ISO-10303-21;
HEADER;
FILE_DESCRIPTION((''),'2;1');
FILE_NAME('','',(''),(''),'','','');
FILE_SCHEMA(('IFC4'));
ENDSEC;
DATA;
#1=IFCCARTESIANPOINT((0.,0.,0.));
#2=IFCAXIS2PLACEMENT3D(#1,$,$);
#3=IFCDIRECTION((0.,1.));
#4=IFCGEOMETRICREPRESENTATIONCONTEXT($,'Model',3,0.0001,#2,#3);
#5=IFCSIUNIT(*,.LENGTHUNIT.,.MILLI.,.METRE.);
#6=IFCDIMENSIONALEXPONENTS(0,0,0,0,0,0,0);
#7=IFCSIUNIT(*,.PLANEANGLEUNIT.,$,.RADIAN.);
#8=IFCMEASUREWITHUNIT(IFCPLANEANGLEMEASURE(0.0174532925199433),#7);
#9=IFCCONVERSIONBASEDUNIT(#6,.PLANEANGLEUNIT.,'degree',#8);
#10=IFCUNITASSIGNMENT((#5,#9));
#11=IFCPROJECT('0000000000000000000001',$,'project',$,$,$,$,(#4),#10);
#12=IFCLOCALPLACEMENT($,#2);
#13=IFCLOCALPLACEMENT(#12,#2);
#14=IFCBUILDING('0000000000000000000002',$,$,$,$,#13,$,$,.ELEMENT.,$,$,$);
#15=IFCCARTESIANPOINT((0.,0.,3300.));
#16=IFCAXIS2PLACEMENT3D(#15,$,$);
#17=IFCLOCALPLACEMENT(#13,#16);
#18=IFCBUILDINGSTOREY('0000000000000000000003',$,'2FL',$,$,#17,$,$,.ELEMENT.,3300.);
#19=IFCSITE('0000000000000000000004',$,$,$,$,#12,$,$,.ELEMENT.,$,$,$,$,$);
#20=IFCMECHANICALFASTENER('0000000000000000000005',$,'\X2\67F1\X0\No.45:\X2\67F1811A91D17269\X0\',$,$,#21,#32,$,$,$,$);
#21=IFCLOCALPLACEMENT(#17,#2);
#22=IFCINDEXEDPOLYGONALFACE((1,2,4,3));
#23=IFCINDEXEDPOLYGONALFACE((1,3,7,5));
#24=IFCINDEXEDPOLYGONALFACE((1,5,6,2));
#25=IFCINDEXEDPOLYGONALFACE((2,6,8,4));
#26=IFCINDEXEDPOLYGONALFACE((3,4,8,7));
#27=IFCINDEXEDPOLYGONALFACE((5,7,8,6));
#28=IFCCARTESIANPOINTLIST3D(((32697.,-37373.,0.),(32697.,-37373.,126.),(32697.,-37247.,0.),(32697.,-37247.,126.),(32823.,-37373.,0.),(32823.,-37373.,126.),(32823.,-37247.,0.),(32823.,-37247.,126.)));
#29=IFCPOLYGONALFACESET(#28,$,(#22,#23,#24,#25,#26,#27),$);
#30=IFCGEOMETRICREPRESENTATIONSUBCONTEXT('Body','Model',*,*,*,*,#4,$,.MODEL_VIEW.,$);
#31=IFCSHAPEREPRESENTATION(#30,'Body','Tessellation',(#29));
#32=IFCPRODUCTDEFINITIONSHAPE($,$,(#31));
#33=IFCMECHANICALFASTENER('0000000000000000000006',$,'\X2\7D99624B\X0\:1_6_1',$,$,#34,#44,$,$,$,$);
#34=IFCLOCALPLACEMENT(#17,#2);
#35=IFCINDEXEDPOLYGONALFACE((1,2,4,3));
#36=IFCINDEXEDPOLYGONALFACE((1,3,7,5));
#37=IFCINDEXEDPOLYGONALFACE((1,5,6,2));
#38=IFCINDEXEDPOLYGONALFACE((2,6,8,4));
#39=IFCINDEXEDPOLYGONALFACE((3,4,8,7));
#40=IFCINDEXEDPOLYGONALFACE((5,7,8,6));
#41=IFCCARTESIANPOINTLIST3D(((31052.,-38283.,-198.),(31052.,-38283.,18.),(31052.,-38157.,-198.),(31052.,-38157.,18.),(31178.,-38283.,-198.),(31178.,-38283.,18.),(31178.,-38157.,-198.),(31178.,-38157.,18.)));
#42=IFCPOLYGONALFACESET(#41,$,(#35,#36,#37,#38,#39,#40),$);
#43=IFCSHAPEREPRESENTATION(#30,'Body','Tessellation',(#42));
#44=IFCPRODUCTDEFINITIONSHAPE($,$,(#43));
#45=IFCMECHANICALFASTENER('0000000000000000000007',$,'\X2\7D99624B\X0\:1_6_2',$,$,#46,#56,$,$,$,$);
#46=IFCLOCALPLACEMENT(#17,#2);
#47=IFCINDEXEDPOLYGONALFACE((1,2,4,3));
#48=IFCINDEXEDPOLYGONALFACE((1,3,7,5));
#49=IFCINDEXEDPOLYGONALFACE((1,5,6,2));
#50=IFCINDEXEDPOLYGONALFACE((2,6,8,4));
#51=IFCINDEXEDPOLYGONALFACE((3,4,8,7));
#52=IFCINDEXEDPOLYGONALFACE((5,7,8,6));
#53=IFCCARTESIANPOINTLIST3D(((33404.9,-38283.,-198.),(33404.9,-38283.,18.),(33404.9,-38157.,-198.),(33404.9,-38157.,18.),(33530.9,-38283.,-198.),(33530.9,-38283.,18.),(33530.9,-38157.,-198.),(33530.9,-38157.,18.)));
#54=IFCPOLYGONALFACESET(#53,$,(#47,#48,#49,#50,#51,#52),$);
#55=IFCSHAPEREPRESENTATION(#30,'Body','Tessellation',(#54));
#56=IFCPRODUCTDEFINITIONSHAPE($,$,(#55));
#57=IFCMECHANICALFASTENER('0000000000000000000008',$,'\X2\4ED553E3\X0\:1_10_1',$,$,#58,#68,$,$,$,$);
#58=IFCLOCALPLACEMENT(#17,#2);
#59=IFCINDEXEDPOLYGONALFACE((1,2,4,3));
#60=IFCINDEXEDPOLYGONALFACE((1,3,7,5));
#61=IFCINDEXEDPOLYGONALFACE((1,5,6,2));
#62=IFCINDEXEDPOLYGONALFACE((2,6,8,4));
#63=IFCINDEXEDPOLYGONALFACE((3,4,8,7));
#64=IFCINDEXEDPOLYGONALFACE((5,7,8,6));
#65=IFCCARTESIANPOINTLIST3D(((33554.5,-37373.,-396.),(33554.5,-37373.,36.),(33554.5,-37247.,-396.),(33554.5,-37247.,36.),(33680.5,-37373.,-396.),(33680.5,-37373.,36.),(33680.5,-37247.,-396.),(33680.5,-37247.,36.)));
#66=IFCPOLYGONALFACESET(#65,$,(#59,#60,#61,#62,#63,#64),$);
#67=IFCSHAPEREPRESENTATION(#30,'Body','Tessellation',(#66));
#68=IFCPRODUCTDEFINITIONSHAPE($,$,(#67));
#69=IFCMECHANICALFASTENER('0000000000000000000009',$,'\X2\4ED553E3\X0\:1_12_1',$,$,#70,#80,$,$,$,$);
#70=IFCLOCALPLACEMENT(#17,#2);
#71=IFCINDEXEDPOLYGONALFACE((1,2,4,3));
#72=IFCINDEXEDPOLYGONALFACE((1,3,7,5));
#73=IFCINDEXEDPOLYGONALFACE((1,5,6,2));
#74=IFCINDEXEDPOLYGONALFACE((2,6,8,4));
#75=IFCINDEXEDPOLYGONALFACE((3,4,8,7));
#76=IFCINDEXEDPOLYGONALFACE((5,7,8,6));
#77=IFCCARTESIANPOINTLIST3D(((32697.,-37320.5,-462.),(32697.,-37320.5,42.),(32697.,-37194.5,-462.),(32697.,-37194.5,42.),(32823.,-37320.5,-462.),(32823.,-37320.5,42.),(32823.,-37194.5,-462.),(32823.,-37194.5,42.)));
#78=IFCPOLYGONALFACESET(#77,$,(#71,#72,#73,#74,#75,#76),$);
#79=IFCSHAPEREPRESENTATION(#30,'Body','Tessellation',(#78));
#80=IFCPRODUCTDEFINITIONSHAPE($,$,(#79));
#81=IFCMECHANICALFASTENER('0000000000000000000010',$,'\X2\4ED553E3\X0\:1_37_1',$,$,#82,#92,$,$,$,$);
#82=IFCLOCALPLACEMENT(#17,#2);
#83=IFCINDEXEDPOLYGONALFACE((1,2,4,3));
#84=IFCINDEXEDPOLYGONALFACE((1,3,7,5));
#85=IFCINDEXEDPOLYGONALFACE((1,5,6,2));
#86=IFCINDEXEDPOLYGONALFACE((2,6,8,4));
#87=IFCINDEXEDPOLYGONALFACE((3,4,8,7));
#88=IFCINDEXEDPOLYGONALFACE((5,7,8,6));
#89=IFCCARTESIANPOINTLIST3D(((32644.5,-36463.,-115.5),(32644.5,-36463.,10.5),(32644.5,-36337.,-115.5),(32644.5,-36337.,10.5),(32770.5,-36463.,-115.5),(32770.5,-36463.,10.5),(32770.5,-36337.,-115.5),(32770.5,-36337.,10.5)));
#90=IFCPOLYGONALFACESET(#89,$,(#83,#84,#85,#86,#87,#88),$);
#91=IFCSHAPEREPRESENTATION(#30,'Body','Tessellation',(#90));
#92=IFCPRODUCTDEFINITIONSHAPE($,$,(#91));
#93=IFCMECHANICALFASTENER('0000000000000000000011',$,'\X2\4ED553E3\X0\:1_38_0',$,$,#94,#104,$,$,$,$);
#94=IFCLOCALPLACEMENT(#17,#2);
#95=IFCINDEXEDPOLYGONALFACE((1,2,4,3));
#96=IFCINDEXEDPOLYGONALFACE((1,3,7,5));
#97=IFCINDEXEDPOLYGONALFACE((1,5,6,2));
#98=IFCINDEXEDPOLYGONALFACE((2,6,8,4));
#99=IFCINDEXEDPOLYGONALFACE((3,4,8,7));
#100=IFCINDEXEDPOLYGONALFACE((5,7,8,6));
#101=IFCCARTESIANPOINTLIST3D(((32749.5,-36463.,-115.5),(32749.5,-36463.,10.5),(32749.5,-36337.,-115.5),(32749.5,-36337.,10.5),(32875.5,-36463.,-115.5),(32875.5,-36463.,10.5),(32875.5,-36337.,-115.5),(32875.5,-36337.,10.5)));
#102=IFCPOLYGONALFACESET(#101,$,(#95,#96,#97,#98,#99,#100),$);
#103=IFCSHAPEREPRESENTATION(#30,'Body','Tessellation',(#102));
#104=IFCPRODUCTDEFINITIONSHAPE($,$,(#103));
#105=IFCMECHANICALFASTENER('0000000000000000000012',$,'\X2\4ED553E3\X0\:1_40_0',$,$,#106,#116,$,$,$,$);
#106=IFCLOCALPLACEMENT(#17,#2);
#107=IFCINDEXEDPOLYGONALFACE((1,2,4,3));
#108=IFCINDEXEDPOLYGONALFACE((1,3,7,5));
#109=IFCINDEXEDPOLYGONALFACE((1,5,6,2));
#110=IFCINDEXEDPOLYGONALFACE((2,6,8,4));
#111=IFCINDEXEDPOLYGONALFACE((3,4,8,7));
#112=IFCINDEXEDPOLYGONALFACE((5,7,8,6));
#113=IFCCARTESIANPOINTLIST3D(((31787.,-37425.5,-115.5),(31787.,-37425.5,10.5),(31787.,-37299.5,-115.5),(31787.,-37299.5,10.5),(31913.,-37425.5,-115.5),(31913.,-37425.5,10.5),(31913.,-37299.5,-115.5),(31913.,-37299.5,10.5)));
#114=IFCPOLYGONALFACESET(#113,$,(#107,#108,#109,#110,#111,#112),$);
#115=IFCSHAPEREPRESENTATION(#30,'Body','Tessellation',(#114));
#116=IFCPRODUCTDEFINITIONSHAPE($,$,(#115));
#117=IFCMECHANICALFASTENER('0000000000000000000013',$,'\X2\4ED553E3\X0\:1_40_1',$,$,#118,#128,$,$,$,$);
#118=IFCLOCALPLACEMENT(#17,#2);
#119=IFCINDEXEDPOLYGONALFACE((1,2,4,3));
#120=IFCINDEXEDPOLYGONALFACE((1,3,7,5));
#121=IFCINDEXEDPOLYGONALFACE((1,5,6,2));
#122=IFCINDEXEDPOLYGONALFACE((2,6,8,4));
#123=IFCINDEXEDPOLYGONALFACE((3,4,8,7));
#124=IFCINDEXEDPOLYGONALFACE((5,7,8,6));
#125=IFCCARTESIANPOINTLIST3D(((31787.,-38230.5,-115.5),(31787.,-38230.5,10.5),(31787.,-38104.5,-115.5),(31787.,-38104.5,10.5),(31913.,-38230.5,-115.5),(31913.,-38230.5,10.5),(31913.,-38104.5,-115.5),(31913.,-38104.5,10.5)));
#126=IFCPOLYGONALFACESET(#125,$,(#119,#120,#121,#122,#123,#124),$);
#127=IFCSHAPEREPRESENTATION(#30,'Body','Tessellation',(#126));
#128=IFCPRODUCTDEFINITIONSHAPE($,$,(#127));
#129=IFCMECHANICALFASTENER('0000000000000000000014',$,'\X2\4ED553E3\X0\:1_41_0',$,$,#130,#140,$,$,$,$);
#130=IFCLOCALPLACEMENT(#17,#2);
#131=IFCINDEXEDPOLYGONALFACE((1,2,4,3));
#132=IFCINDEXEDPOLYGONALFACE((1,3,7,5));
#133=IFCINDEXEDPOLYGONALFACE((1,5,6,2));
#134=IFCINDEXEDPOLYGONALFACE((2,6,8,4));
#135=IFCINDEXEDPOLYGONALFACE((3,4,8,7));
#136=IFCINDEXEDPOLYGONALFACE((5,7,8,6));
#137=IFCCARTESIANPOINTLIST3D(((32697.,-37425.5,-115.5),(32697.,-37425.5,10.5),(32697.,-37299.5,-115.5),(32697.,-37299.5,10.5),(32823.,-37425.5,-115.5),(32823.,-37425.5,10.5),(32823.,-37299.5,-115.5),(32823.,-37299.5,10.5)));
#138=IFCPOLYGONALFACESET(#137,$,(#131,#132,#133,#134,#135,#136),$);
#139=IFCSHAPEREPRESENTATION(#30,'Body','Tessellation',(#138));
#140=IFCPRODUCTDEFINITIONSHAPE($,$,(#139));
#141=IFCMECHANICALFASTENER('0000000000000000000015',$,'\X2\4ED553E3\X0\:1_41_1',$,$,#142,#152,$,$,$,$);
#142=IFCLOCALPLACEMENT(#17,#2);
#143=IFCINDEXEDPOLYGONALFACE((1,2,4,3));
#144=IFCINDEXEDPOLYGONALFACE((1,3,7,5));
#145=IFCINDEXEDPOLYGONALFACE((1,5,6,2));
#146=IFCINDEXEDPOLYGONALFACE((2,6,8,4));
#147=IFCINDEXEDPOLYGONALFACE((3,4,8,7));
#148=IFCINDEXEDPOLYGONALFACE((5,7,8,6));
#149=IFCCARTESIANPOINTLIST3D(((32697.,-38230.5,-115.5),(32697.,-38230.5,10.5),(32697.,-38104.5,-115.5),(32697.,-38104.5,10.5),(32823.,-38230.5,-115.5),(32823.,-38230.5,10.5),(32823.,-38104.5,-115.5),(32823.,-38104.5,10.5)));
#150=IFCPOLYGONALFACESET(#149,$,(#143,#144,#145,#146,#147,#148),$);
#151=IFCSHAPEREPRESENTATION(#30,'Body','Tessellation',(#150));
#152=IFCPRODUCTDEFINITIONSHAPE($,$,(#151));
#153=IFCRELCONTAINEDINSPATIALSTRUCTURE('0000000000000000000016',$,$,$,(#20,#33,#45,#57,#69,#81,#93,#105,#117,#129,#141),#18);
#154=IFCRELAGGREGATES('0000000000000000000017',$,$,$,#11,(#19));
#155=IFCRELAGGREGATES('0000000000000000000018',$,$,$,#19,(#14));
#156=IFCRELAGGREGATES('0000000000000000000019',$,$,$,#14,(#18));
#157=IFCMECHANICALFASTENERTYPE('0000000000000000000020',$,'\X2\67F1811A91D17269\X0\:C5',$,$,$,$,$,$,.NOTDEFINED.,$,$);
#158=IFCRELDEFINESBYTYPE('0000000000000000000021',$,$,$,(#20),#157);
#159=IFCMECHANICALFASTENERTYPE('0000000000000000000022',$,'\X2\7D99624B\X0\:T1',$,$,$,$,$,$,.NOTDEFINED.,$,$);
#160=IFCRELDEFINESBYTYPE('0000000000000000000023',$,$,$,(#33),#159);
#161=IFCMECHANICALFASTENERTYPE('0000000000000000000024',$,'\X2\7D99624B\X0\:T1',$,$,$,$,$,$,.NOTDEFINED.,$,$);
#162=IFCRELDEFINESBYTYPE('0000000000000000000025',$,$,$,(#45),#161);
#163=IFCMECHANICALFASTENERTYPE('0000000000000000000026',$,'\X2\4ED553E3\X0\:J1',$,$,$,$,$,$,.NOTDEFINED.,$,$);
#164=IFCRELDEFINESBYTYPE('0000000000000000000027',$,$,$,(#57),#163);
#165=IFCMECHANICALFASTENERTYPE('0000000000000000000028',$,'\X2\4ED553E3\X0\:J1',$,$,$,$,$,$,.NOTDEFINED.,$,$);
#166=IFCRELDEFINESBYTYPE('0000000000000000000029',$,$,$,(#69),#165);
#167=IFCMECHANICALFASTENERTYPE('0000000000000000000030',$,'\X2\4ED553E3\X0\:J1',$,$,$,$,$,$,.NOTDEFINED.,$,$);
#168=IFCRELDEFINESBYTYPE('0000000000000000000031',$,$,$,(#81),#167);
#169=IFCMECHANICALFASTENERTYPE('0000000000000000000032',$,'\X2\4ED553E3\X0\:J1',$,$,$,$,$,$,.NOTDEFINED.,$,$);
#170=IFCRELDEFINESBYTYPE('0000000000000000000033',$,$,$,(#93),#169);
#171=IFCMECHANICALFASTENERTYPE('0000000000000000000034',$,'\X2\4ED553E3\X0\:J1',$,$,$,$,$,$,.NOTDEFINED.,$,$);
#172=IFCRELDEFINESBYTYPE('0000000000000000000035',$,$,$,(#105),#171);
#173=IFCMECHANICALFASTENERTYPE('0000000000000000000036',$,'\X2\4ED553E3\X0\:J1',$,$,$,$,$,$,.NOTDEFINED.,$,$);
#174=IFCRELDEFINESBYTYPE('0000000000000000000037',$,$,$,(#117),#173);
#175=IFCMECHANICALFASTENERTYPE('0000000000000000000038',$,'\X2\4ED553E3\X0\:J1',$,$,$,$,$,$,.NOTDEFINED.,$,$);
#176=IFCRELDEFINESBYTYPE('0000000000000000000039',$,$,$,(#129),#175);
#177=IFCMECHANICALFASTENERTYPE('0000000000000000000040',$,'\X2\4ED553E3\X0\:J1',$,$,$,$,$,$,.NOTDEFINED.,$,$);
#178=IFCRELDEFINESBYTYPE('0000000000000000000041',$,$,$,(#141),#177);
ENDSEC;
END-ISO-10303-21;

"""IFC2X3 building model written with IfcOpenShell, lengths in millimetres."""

from ifc_helpers import new_model, entity, si_unit, converted_unit, direction, frame, origin, origin_with_axes, origin_2d, place, context, subcontext, project, spatial, rectangle, extrude, type_object, element, save


model = new_model("IFC2X3")

# Units and contexts
model_context = context("Model", 3, precision=0.0001, world=origin(), true_north=direction((0.0, 1.0)))
body_context = subcontext(model_context, "Body", "Model", "MODEL_VIEW")
ifc_project = project(units=[si_unit("LENGTHUNIT", "METRE", prefix="MILLI"), converted_unit("PLANEANGLEUNIT", "degree", entity("IfcPlaneAngleMeasure", 0.0174532925199433), si_unit("PLANEANGLEUNIT", "RADIAN"), dimensions=[0, 0, 0, 0, 0, 0, 0])], contexts=[model_context])

# Site, building, storey
site_placement = place(None, origin())
site = spatial("IfcSite", under=ifc_project, at=site_placement, CompositionType="ELEMENT")
building_placement = place(site_placement, origin())
building = spatial("IfcBuilding", under=site, at=building_placement, CompositionType="ELEMENT")
storey_placement = place(building_placement, frame((0.0, 0.0, 3300.0)))
storey = spatial("IfcBuildingStorey", under=building, at=storey_placement, Name="2FL", CompositionType="ELEMENT", Elevation=3300.0)

# Mechanical fasteners
mechanical_fastener_type_1 = type_object("IfcMechanicalFastenerType", Name="柱脚金物:C5")
mechanical_fastener_1_placement = place(storey_placement, frame((32760.0, -37310.0, 0.0)))
element("IfcMechanicalFastener", 1, at=mechanical_fastener_1_placement, inside=storey, type_object=mechanical_fastener_type_1, Name="柱No.45:柱脚金物", context=body_context, shape_type="SweptSolid", body=[
    extrude(rectangle(XDim=126.0, YDim=126.0, at=origin_2d()), origin_with_axes(), (0.0, 0.0, 1.0), 126.0),
])
mechanical_fastener_type_2 = type_object("IfcMechanicalFastenerType", Name="継手:T1")
mechanical_fastener_2_placement = place(storey_placement, frame((31115.0, -38220.0, -198.0)))
element("IfcMechanicalFastener", 2, at=mechanical_fastener_2_placement, inside=storey, type_object=mechanical_fastener_type_2, Name="継手:1_6_1", context=body_context, shape_type="SweptSolid", body=[
    extrude(rectangle(XDim=126.0, YDim=126.0, at=origin_2d()), origin_with_axes(), (0.0, 0.0, 1.0), 216.0),
])
mechanical_fastener_type_3 = type_object("IfcMechanicalFastenerType", Name="継手:T1")
mechanical_fastener_3_placement = place(storey_placement, frame((33467.9, -38220.0, -198.0)))
element("IfcMechanicalFastener", 3, at=mechanical_fastener_3_placement, inside=storey, type_object=mechanical_fastener_type_3, Name="継手:1_6_2", context=body_context, shape_type="SweptSolid", body=[
    extrude(rectangle(XDim=126.0, YDim=126.0, at=origin_2d()), origin_with_axes(), (0.0, 0.0, 1.0), 216.0),
])
mechanical_fastener_type_4 = type_object("IfcMechanicalFastenerType", Name="仕口:J1")
mechanical_fastener_4_placement = place(storey_placement, frame((33617.5, -37310.0, -396.0)))
element("IfcMechanicalFastener", 4, at=mechanical_fastener_4_placement, inside=storey, type_object=mechanical_fastener_type_4, Name="仕口:1_10_1", context=body_context, shape_type="SweptSolid", body=[
    extrude(rectangle(XDim=126.0, YDim=126.0, at=origin_2d()), origin_with_axes(), (0.0, 0.0, 1.0), 432.0),
])
mechanical_fastener_type_5 = type_object("IfcMechanicalFastenerType", Name="仕口:J1")
mechanical_fastener_5_placement = place(storey_placement, frame((32760.0, -37257.5, -462.0)))
element("IfcMechanicalFastener", 5, at=mechanical_fastener_5_placement, inside=storey, type_object=mechanical_fastener_type_5, Name="仕口:1_12_1", context=body_context, shape_type="SweptSolid", body=[
    extrude(rectangle(XDim=126.0, YDim=126.0, at=origin_2d()), origin_with_axes(), (0.0, 0.0, 1.0), 504.0),
])
mechanical_fastener_type_6 = type_object("IfcMechanicalFastenerType", Name="仕口:J1")
mechanical_fastener_6_placement = place(storey_placement, frame((32707.5, -36400.0, -115.5)))
element("IfcMechanicalFastener", 6, at=mechanical_fastener_6_placement, inside=storey, type_object=mechanical_fastener_type_6, Name="仕口:1_37_1", context=body_context, shape_type="SweptSolid", body=[
    extrude(rectangle(XDim=126.0, YDim=126.0, at=origin_2d()), origin_with_axes(), (0.0, 0.0, 1.0), 126.0),
])
mechanical_fastener_type_7 = type_object("IfcMechanicalFastenerType", Name="仕口:J1")
mechanical_fastener_7_placement = place(storey_placement, frame((32812.5, -36400.0, -115.5)))
element("IfcMechanicalFastener", 7, at=mechanical_fastener_7_placement, inside=storey, type_object=mechanical_fastener_type_7, Name="仕口:1_38_0", context=body_context, shape_type="SweptSolid", body=[
    extrude(rectangle(XDim=126.0, YDim=126.0, at=origin_2d()), origin_with_axes(), (0.0, 0.0, 1.0), 126.0),
])
mechanical_fastener_type_8 = type_object("IfcMechanicalFastenerType", Name="仕口:J1")
mechanical_fastener_8_placement = place(storey_placement, frame((31850.0, -37362.5, -115.5)))
element("IfcMechanicalFastener", 8, at=mechanical_fastener_8_placement, inside=storey, type_object=mechanical_fastener_type_8, Name="仕口:1_40_0", context=body_context, shape_type="SweptSolid", body=[
    extrude(rectangle(XDim=126.0, YDim=126.0, at=origin_2d()), origin_with_axes(), (0.0, 0.0, 1.0), 126.0),
])
mechanical_fastener_type_9 = type_object("IfcMechanicalFastenerType", Name="仕口:J1")
mechanical_fastener_9_placement = place(storey_placement, frame((31850.0, -38167.5, -115.5)))
element("IfcMechanicalFastener", 9, at=mechanical_fastener_9_placement, inside=storey, type_object=mechanical_fastener_type_9, Name="仕口:1_40_1", context=body_context, shape_type="SweptSolid", body=[
    extrude(rectangle(XDim=126.0, YDim=126.0, at=origin_2d()), origin_with_axes(), (0.0, 0.0, 1.0), 126.0),
])
mechanical_fastener_type_10 = type_object("IfcMechanicalFastenerType", Name="仕口:J1")
mechanical_fastener_10_placement = place(storey_placement, frame((32760.0, -37362.5, -115.5)))
element("IfcMechanicalFastener", 10, at=mechanical_fastener_10_placement, inside=storey, type_object=mechanical_fastener_type_10, Name="仕口:1_41_0", context=body_context, shape_type="SweptSolid", body=[
    extrude(rectangle(XDim=126.0, YDim=126.0, at=origin_2d()), origin_with_axes(), (0.0, 0.0, 1.0), 126.0),
])
mechanical_fastener_type_11 = type_object("IfcMechanicalFastenerType", Name="仕口:J1")
mechanical_fastener_11_placement = place(storey_placement, frame((32760.0, -38167.5, -115.5)))
element("IfcMechanicalFastener", 11, at=mechanical_fastener_11_placement, inside=storey, type_object=mechanical_fastener_type_11, Name="仕口:1_41_1", context=body_context, shape_type="SweptSolid", body=[
    extrude(rectangle(XDim=126.0, YDim=126.0, at=origin_2d()), origin_with_axes(), (0.0, 0.0, 1.0), 126.0),
])

save(model, "model.ifc")
